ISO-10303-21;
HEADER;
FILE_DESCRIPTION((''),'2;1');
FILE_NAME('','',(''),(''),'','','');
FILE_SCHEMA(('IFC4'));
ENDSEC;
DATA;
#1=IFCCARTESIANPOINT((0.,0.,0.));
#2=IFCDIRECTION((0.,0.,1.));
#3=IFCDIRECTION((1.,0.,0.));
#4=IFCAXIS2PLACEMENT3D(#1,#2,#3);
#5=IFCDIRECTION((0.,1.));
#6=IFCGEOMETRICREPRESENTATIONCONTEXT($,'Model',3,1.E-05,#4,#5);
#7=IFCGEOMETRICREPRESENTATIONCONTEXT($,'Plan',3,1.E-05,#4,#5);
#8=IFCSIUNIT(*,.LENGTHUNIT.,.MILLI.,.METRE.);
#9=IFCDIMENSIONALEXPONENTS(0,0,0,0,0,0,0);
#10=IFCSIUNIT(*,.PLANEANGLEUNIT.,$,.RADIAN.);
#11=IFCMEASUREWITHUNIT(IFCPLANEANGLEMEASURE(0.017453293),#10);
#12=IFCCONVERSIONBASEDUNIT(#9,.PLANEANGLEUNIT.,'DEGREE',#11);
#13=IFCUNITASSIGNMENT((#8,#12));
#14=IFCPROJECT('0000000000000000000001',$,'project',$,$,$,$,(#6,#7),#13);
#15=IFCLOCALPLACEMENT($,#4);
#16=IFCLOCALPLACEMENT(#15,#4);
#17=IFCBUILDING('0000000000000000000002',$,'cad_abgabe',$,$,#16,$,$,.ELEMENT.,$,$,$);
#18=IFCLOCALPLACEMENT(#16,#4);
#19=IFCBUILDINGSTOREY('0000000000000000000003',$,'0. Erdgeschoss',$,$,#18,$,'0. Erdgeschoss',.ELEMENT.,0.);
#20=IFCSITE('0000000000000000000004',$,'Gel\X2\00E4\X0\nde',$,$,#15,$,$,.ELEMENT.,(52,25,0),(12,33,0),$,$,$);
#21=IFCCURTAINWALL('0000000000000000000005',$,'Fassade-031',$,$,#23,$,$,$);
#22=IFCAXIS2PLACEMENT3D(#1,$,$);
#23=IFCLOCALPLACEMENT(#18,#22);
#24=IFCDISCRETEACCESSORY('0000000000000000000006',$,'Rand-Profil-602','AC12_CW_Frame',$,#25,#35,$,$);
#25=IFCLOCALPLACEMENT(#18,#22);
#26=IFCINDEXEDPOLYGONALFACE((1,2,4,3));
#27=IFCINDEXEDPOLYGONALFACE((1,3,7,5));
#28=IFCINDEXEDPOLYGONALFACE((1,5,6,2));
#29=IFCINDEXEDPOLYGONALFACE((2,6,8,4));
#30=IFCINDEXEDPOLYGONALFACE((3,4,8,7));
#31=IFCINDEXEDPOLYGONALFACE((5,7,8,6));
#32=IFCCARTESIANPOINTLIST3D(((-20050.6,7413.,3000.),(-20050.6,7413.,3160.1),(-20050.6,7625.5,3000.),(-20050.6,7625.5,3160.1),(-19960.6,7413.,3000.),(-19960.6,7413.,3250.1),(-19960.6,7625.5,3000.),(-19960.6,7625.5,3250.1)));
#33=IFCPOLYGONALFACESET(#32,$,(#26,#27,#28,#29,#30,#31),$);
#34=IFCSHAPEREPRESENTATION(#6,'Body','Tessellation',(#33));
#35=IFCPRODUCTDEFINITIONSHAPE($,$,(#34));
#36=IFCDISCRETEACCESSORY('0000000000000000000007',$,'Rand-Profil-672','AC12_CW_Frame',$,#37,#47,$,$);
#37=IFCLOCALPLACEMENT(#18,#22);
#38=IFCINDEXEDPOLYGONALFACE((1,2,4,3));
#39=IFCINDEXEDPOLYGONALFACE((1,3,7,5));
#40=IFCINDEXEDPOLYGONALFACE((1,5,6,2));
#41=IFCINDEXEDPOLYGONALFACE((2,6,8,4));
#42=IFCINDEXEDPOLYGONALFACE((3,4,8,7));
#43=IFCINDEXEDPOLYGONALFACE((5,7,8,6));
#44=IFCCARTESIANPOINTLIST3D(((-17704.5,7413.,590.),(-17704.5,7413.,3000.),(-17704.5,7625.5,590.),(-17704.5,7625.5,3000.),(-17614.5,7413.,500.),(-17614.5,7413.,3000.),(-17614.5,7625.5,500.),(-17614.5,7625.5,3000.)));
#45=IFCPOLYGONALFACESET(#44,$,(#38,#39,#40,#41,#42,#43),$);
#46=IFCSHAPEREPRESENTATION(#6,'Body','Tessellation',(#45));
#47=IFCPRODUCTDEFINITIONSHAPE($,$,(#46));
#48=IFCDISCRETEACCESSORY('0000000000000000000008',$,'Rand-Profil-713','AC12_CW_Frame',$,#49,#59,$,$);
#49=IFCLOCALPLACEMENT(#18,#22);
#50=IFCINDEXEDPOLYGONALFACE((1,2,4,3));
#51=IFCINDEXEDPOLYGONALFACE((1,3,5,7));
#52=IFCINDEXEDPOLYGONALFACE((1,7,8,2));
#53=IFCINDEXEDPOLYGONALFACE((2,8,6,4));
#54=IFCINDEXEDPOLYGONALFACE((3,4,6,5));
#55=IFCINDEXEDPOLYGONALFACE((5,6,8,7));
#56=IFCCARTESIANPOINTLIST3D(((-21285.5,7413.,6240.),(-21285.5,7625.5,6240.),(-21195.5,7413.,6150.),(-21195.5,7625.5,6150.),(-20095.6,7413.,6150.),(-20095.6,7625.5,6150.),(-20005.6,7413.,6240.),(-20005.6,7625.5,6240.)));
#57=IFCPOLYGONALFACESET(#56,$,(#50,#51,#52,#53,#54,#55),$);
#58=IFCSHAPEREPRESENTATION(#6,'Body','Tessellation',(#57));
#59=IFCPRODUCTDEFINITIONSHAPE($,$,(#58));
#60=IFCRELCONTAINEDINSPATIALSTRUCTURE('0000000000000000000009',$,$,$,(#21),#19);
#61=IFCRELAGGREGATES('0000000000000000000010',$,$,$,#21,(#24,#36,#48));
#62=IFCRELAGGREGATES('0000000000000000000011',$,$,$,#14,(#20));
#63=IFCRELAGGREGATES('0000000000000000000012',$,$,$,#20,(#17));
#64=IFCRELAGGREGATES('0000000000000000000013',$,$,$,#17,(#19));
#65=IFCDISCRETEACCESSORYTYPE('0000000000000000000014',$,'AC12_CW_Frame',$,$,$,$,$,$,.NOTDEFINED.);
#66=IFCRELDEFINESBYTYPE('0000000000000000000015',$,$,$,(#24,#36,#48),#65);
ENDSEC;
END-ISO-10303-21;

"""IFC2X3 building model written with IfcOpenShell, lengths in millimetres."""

from ifc_helpers import new_model, entity, si_unit, converted_unit, direction, frame, origin_with_axes, place, context, project, spatial, polyline, outline, extrude, source, transform, mapped, type_object, element, aggregate, save


model = new_model("IFC2X3")

# Units and contexts
model_context = context("Model", 3, precision=1e-05, world=origin_with_axes(), true_north=direction((0.0, 1.0)))
plan_context = context("Plan", 3, precision=1e-05, world=origin_with_axes(), true_north=direction((0.0, 1.0)))
ifc_project = project(units=[si_unit("LENGTHUNIT", "METRE", prefix="MILLI"), converted_unit("PLANEANGLEUNIT", "DEGREE", entity("IfcPlaneAngleMeasure", 0.017453293), si_unit("PLANEANGLEUNIT", "RADIAN"), dimensions=[0, 0, 0, 0, 0, 0, 0])], contexts=[model_context, plan_context])

# Site, building, storey
site_placement = place(None, origin_with_axes())
site = spatial("IfcSite", under=ifc_project, at=site_placement, Name="Gelände", CompositionType="ELEMENT", RefLatitude=(52, 25, 0), RefLongitude=(12, 33, 0))
building_placement = place(site_placement, origin_with_axes())
building = spatial("IfcBuilding", under=site, at=building_placement, Name="cad_abgabe", CompositionType="ELEMENT")
storey_placement = place(building_placement, origin_with_axes())
storey = spatial("IfcBuildingStorey", under=building, at=storey_placement, Name="0. Erdgeschoss", LongName="0. Erdgeschoss", CompositionType="ELEMENT", Elevation=0.0)

# Curtain wall, discrete accessories
curtain_wall_placement = place(storey_placement, frame((-17614.5, 7448.0, 500.0), z_axis=(0.0, 0.0, 1.0), x_axis=(-1.0, 0.0, 0.0)))
curtain_wall = element("IfcCurtainWall", 1, at=curtain_wall_placement, inside=storey, Name="Fassade-031")
discrete_accessory_type = type_object("IfcDiscreteAccessoryType", Name="AC12_CW_Frame")
shared_shape_1 = source(origin_with_axes(), model_context, "Body", "SweptSolid", [
    extrude(outline(polyline([(0.0, 0.0), (160.1, 0.0), (250.1, -90.0), (0.0, -90.0), (0.0, 0.0)])), origin_with_axes(), (0.0, 0.0, 1.0), 212.5),
])
discrete_accessory_1_placement = place(storey_placement, frame((-20050.6, 7625.5, 3000.0), z_axis=(0.0, -1.0, 0.0), x_axis=(0.0, 0.0, 1.0)))
discrete_accessory_1 = element("IfcDiscreteAccessory", 2, at=discrete_accessory_1_placement, type_object=discrete_accessory_type, Name="Rand-Profil-602", Description="AC12_CW_Frame", context=model_context, shape_type="MappedRepresentation", body=[
    mapped(shared_shape_1, transform((0.0, 0.0, 0.0), scale=1.0)),
])
shared_shape_2 = source(origin_with_axes(), model_context, "Body", "SweptSolid", [
    extrude(outline(polyline([(0.0, 0.0), (2500.0, 0.0), (2410.0, -90.0), (0.0, -90.0), (0.0, 0.0)])), origin_with_axes(), (0.0, 0.0, 1.0), 212.5),
])
discrete_accessory_2_placement = place(storey_placement, frame((-17614.5, 7625.5, 3000.0), z_axis=(0.0, -1.0, 0.0), x_axis=(0.0, 0.0, -1.0)))
discrete_accessory_2 = element("IfcDiscreteAccessory", 3, at=discrete_accessory_2_placement, type_object=discrete_accessory_type, Name="Rand-Profil-672", Description="AC12_CW_Frame", context=model_context, shape_type="MappedRepresentation", body=[
    mapped(shared_shape_2, transform((0.0, 0.0, 0.0), scale=1.0)),
])
shared_shape_3 = source(origin_with_axes(), model_context, "Body", "SweptSolid", [
    extrude(outline(polyline([(0.0, 0.0), (1279.8, 0.0), (1189.8, -90.0), (90.0, -90.0), (0.0, 0.0)])), origin_with_axes(), (0.0, 0.0, 1.0), 212.5),
])
discrete_accessory_3_placement = place(storey_placement, frame((-21285.5, 7625.5, 6240.0), z_axis=(0.0, -1.0, 0.0), x_axis=(1.0, 0.0, 0.0)))
discrete_accessory_3 = element("IfcDiscreteAccessory", 4, at=discrete_accessory_3_placement, type_object=discrete_accessory_type, Name="Rand-Profil-713", Description="AC12_CW_Frame", context=model_context, shape_type="MappedRepresentation", body=[
    mapped(shared_shape_3, transform((0.0, 0.0, 0.0), scale=1.0)),
])
aggregate(curtain_wall, [discrete_accessory_1, discrete_accessory_2, discrete_accessory_3])

save(model, "model.ifc")
